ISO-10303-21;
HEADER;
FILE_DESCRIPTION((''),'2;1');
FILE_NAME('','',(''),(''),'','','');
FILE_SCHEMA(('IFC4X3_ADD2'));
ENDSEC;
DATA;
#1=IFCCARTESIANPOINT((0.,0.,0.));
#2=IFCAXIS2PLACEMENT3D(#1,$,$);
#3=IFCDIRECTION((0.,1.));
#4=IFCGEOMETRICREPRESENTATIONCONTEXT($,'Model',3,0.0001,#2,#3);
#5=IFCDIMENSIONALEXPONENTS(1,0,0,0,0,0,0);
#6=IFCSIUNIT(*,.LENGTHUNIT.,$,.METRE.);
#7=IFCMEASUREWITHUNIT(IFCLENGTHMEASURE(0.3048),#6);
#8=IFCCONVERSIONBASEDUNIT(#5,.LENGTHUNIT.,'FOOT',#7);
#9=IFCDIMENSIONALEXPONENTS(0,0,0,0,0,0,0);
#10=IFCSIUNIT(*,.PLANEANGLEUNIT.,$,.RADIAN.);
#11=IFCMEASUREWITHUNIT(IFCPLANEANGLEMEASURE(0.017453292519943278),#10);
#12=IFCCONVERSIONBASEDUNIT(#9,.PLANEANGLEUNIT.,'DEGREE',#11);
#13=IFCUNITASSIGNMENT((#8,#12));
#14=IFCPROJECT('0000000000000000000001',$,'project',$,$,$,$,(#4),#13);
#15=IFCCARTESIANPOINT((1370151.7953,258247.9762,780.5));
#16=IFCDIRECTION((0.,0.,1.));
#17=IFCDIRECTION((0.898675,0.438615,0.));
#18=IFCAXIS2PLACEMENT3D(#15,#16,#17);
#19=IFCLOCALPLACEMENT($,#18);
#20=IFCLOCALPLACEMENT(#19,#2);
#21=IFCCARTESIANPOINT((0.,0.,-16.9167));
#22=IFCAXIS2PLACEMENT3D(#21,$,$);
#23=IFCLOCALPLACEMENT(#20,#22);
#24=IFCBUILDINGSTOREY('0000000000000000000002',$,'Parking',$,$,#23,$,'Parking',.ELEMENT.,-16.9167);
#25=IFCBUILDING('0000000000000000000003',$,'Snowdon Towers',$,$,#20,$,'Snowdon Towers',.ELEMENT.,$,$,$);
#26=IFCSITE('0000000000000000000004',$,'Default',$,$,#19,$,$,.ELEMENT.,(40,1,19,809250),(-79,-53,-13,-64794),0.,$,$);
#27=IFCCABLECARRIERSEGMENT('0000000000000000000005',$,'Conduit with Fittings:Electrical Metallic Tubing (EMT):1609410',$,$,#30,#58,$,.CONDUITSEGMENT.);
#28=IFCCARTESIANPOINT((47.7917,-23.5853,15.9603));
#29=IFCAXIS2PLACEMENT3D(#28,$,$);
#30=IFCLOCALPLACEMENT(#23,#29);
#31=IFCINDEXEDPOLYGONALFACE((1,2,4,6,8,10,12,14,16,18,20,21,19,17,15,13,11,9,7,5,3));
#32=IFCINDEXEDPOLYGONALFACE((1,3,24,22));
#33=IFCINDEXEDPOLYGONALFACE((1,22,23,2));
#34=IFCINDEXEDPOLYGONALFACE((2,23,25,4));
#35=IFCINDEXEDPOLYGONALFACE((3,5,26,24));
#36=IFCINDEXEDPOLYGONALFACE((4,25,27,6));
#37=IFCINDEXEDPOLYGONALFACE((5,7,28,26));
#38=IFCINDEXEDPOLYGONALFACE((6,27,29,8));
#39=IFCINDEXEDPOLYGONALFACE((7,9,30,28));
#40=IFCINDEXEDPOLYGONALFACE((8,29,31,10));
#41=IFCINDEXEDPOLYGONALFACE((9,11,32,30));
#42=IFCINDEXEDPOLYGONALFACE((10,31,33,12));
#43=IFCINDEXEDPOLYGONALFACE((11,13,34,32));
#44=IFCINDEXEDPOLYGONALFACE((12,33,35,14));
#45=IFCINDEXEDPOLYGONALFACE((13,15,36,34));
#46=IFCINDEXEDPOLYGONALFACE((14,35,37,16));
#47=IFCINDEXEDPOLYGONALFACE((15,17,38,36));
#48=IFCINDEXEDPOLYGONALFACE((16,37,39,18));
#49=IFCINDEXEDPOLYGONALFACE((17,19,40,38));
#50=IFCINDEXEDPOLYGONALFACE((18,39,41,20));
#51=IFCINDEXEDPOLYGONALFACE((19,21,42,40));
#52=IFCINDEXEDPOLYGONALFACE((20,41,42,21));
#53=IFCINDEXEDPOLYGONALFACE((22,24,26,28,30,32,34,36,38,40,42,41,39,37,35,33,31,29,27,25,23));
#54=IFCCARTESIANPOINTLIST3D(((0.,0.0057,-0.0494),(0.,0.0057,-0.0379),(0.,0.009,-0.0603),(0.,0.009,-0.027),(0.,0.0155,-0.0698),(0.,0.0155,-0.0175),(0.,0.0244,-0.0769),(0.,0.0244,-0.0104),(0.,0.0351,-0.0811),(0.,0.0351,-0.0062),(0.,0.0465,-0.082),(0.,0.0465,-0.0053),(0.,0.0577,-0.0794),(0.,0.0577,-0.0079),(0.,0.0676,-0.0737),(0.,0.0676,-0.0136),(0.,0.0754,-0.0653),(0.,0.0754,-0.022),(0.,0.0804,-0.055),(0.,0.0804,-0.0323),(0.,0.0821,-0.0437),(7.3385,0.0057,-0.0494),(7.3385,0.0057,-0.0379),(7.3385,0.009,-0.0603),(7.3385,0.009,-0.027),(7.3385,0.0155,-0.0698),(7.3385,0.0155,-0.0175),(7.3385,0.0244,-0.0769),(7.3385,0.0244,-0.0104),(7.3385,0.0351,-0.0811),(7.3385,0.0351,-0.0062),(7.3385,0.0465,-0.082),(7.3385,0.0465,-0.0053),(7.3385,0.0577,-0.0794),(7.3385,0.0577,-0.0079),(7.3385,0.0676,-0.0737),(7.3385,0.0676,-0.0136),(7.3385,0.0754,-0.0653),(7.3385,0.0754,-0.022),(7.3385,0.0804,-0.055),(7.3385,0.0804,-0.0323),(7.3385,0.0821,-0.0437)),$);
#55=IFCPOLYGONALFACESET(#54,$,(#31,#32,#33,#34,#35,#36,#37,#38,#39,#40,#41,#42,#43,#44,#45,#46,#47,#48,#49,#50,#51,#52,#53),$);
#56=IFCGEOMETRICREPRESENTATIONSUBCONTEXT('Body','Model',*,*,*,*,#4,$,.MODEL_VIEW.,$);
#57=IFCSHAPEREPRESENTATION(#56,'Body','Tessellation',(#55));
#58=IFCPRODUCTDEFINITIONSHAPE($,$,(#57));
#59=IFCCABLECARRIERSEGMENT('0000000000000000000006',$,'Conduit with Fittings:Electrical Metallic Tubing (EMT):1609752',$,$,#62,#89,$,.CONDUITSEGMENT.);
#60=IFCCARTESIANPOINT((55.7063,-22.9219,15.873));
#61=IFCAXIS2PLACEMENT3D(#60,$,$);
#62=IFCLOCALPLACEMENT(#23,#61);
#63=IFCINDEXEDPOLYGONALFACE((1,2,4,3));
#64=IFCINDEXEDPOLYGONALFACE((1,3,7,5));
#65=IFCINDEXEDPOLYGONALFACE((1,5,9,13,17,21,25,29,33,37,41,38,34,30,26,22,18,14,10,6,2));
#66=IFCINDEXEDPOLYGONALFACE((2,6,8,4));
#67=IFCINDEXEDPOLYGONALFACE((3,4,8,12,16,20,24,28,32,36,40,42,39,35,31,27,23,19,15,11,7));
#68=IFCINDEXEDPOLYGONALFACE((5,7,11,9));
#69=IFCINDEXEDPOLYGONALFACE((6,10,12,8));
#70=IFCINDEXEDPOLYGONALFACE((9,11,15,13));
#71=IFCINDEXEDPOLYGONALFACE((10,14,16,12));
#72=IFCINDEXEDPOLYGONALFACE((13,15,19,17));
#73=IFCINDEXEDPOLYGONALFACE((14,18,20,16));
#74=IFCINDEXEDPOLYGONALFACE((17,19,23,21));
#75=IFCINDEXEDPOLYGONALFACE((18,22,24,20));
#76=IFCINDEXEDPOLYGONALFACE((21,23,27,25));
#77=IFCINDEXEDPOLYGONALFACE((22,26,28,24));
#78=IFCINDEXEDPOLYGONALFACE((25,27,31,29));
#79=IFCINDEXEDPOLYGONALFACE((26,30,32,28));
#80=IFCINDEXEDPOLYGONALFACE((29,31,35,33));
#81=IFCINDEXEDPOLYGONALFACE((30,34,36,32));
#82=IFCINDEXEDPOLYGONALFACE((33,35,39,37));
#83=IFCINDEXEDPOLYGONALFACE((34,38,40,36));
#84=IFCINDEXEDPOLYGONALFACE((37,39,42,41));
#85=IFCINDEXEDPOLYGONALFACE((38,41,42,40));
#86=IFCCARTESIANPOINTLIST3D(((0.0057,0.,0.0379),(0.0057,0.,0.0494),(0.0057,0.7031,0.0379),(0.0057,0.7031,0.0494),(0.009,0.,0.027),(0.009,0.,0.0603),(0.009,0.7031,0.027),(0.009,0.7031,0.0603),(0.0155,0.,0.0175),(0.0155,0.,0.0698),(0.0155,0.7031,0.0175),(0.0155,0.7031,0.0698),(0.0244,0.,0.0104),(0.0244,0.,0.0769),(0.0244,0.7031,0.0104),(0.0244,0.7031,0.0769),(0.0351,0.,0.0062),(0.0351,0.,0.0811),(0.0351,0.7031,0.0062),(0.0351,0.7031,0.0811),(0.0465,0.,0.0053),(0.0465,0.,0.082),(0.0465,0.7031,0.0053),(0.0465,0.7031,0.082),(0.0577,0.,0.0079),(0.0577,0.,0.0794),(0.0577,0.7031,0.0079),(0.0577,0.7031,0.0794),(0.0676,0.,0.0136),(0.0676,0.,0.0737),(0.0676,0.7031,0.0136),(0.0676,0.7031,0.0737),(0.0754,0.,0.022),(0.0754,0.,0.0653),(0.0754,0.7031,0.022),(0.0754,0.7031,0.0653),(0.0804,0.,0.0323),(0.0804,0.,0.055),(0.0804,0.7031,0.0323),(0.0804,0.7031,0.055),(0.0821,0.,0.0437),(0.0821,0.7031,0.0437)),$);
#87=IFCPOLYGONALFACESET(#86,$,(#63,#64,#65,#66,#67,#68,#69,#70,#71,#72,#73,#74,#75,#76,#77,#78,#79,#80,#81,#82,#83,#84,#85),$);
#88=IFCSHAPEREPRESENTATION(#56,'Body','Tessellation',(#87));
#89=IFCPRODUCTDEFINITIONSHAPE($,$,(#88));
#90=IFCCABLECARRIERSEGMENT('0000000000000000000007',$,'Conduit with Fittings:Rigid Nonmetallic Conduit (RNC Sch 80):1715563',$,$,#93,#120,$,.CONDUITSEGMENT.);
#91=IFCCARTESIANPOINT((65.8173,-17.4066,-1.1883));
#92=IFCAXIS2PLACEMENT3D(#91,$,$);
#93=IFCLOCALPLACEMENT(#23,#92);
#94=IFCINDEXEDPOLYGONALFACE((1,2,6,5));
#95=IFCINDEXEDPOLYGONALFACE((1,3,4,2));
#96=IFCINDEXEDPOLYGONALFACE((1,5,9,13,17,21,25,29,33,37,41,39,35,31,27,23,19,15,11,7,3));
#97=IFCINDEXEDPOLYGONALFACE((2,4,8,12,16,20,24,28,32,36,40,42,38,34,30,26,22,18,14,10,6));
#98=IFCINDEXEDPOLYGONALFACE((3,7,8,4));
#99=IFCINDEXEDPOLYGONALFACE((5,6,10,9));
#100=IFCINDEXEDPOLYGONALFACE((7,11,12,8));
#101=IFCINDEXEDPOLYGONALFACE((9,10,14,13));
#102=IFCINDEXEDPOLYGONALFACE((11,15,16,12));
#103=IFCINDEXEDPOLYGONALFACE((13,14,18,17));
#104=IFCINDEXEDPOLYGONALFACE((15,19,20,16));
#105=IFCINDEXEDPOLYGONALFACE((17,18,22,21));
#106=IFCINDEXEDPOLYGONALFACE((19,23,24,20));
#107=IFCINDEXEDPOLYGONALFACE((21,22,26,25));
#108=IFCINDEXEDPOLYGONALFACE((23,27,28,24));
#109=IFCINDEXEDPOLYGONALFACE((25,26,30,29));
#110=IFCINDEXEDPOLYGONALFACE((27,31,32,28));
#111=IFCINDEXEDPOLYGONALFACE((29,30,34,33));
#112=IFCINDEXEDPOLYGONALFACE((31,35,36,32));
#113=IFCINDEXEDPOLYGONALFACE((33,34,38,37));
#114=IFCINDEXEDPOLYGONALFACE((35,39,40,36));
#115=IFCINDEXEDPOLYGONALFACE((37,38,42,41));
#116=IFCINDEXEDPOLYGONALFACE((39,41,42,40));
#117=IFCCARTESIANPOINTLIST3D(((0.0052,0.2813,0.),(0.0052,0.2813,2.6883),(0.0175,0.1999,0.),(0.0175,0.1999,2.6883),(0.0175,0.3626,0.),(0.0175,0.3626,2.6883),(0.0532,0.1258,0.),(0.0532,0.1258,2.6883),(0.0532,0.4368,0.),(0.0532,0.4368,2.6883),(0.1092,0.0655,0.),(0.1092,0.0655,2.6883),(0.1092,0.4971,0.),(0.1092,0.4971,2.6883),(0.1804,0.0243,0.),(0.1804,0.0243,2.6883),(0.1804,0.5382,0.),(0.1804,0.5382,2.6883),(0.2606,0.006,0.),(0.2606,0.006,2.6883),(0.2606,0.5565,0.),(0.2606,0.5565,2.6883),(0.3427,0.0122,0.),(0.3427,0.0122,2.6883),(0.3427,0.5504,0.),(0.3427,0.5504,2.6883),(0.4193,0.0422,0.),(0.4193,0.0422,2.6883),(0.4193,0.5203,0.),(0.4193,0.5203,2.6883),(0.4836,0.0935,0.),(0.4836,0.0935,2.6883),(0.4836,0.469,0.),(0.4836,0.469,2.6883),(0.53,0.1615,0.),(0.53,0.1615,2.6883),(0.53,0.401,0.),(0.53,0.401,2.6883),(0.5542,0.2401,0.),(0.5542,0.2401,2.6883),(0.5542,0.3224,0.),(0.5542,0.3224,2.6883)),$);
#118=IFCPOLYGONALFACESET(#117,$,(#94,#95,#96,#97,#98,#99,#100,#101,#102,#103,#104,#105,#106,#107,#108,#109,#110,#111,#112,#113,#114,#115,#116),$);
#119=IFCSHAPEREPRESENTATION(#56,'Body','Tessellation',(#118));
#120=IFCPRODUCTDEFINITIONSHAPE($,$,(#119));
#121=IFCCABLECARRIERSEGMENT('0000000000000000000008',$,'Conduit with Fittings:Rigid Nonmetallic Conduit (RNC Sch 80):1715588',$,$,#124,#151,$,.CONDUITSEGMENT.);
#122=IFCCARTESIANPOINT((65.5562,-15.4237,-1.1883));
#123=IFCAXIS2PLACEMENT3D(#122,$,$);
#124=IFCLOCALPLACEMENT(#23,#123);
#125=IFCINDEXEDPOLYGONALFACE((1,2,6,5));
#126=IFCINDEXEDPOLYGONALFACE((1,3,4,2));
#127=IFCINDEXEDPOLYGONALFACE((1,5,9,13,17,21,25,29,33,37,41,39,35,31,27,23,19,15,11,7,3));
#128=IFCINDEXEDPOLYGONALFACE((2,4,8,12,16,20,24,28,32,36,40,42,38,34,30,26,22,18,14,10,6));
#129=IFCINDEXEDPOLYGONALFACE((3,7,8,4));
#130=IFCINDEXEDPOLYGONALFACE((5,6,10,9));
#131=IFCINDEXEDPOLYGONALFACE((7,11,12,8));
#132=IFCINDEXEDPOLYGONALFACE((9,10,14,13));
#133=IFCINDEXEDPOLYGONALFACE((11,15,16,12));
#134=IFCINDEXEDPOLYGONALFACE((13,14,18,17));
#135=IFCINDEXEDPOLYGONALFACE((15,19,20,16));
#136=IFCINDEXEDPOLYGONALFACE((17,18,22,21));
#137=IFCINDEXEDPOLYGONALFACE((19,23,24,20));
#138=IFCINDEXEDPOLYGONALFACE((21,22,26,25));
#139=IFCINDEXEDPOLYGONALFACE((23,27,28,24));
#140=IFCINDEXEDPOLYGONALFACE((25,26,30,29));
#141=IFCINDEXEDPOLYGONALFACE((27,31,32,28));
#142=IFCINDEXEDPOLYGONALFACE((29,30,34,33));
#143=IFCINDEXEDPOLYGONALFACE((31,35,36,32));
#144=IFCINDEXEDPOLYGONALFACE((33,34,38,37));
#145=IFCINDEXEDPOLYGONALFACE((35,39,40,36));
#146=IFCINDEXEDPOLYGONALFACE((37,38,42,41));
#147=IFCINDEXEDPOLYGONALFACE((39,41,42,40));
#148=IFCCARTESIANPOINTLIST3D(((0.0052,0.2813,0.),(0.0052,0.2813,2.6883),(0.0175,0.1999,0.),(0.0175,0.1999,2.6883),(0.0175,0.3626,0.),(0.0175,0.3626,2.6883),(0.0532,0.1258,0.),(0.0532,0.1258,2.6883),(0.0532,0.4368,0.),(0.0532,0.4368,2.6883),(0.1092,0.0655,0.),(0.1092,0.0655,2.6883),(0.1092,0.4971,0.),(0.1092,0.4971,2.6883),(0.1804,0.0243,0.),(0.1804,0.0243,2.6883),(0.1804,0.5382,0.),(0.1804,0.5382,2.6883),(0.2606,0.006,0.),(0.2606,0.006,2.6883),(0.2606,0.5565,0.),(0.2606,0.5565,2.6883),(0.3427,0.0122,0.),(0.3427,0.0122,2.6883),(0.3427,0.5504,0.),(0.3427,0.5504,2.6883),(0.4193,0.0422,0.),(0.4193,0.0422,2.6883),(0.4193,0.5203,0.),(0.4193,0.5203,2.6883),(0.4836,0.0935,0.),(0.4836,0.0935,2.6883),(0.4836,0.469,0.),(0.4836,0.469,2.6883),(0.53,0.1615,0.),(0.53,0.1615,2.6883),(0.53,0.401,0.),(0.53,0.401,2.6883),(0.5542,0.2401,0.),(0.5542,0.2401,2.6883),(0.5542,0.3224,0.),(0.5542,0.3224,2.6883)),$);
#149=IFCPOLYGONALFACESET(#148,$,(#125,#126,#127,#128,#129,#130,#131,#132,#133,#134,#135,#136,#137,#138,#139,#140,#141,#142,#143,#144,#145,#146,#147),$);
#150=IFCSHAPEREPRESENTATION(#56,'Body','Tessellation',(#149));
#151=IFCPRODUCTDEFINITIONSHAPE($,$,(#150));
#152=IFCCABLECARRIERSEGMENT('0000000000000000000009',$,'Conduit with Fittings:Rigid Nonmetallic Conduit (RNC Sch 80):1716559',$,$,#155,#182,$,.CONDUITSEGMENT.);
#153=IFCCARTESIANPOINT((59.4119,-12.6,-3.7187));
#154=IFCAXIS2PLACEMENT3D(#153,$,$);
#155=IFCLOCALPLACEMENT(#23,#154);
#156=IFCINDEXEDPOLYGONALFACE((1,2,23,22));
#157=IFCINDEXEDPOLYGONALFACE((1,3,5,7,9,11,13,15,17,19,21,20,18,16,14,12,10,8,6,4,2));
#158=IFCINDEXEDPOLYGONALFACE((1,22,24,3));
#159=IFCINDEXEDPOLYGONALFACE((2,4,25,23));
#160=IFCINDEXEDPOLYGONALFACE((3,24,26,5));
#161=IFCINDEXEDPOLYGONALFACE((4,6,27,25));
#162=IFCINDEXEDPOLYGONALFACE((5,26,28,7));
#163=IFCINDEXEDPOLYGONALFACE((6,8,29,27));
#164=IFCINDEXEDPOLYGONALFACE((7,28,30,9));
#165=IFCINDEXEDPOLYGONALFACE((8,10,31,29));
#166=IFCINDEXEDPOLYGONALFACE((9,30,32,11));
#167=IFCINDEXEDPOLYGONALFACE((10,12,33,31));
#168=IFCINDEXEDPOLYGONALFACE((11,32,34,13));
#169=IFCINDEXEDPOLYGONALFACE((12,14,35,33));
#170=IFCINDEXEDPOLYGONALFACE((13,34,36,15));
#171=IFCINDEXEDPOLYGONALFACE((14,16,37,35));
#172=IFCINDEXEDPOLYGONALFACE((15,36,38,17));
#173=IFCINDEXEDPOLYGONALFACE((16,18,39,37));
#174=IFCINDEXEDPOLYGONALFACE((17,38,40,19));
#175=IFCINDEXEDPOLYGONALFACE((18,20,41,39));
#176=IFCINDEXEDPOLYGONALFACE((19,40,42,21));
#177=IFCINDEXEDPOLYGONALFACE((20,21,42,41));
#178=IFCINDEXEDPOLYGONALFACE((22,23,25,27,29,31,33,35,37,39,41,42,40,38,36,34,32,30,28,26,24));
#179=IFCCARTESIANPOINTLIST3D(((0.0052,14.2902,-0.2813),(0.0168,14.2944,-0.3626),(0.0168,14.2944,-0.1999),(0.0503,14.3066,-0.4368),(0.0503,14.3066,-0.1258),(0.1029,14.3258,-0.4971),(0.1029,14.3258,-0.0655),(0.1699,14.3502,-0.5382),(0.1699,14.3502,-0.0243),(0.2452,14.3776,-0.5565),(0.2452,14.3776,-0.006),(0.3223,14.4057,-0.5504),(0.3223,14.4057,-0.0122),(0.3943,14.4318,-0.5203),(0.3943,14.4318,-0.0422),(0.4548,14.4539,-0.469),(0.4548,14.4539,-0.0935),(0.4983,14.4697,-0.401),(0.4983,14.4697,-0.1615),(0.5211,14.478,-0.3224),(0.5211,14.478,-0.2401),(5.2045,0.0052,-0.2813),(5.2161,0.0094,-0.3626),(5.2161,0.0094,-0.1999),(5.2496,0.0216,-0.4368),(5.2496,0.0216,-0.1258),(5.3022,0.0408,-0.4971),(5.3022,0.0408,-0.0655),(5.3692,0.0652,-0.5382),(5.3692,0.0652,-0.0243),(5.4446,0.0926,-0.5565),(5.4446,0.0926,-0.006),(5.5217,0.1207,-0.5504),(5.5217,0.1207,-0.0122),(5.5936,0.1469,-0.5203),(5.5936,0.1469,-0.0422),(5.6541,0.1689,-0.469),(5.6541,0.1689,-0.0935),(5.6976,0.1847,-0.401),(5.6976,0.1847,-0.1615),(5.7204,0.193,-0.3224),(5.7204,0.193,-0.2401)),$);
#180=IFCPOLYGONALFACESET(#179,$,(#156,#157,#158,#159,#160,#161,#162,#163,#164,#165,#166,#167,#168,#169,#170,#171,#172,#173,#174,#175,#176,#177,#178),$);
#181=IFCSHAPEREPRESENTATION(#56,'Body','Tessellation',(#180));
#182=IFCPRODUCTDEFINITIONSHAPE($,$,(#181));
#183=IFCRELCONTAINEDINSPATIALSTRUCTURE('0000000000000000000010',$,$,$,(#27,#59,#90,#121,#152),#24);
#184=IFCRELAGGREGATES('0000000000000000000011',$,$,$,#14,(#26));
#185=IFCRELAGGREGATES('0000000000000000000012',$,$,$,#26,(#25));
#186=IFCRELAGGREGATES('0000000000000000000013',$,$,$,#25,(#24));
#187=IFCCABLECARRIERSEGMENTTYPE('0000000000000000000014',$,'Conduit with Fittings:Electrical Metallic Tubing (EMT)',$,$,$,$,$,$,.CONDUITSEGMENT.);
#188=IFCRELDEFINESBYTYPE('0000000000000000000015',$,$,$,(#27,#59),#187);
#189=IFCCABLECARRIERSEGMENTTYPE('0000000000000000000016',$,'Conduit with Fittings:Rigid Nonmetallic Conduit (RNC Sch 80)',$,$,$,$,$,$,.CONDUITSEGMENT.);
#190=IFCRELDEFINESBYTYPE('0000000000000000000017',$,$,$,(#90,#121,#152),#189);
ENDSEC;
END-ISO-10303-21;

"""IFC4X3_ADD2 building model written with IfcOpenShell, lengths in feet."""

from ifc_helpers import new_model, entity, si_unit, converted_unit, direction, frame, frame_2d, origin, place, context, subcontext, project, spatial, circle, extrude, type_object, element, save


model = new_model("IFC4X3_ADD2")

# Units and contexts
model_context = context("Model", 3, precision=0.0001, world=origin(), true_north=direction((0.0, 1.0)))
body_context = subcontext(model_context, "Body", "Model", "MODEL_VIEW")
ifc_project = project(units=[converted_unit("LENGTHUNIT", "FOOT", entity("IfcLengthMeasure", 0.3048), si_unit("LENGTHUNIT", "METRE"), dimensions=[1, 0, 0, 0, 0, 0, 0]), converted_unit("PLANEANGLEUNIT", "DEGREE", entity("IfcPlaneAngleMeasure", 0.017453292519943278), si_unit("PLANEANGLEUNIT", "RADIAN"), dimensions=[0, 0, 0, 0, 0, 0, 0])], contexts=[model_context])

# Site, building, storey
site_placement = place(None, frame((1370151.7953, 258247.9762, 780.5), z_axis=(0.0, 0.0, 1.0), x_axis=(0.898675, 0.438615, 0.0)))
site = spatial("IfcSite", under=ifc_project, at=site_placement, Name="Default", CompositionType="ELEMENT", RefLatitude=(40, 1, 19, 809250), RefLongitude=(-79, -53, -13, -64794), RefElevation=0.0)
building_placement = place(site_placement, origin())
building = spatial("IfcBuilding", under=site, at=building_placement, Name="Snowdon Towers", LongName="Snowdon Towers", CompositionType="ELEMENT")
storey_placement = place(building_placement, frame((0.0, 0.0, -16.9167)))
storey = spatial("IfcBuildingStorey", under=building, at=storey_placement, Name="Parking", LongName="Parking", CompositionType="ELEMENT", Elevation=-16.9167)

# Cable carrier segments
cable_carrier_segment_type_1 = type_object("IfcCableCarrierSegmentType", Name="Conduit with Fittings:Electrical Metallic Tubing (EMT)", PredefinedType="CONDUITSEGMENT")
cable_carrier_segment_1_placement = place(storey_placement, frame((47.7917, -23.5853, 15.9603)))
element("IfcCableCarrierSegment", 1, at=cable_carrier_segment_1_placement, inside=storey, type_object=cable_carrier_segment_type_1, Name="Conduit with Fittings:Electrical Metallic Tubing (EMT):1609410", PredefinedType="CONDUITSEGMENT", context=body_context, shape_type="SweptSolid", body=[
    extrude(circle(Radius=0.0384, at=frame_2d((0.0, 0.0), x_axis=(1.0, 0.0))), frame((0.0, 0.0437, -0.0437), z_axis=(1.0, 0.0, 0.0), x_axis=(0.0, 1.0, 0.0)), (0.0, 0.0, 1.0), 7.3385),
])
cable_carrier_segment_2_placement = place(storey_placement, frame((55.7063, -22.9219, 15.873)))
element("IfcCableCarrierSegment", 2, at=cable_carrier_segment_2_placement, inside=storey, type_object=cable_carrier_segment_type_1, Name="Conduit with Fittings:Electrical Metallic Tubing (EMT):1609752", PredefinedType="CONDUITSEGMENT", context=body_context, shape_type="SweptSolid", body=[
    extrude(circle(Radius=0.0384, at=frame_2d((0.0, 0.0), x_axis=(1.0, 0.0))), frame((0.0437, 0.0, 0.0437), z_axis=(0.0, 1.0, 0.0), x_axis=(1.0, 0.0, 0.0)), (0.0, 0.0, 1.0), 0.7031),
])

# Cable carrier segments
cable_carrier_segment_type_2 = type_object("IfcCableCarrierSegmentType", Name="Conduit with Fittings:Rigid Nonmetallic Conduit (RNC Sch 80)", PredefinedType="CONDUITSEGMENT")
cable_carrier_segment_3_placement = place(storey_placement, frame((65.8173, -17.4066, -1.1883)))
element("IfcCableCarrierSegment", 3, at=cable_carrier_segment_3_placement, inside=storey, type_object=cable_carrier_segment_type_2, Name="Conduit with Fittings:Rigid Nonmetallic Conduit (RNC Sch 80):1715563", PredefinedType="CONDUITSEGMENT", context=body_context, shape_type="SweptSolid", body=[
    extrude(circle(Radius=0.276, at=frame_2d((0.0, 0.0), x_axis=(1.0, 0.0))), frame((0.2813, 0.2813, 0.0), z_axis=(0.0, 0.0, 1.0), x_axis=(-1.0, 0.0, 0.0)), (0.0, 0.0, 1.0), 2.6883),
])
cable_carrier_segment_4_placement = place(storey_placement, frame((65.5562, -15.4237, -1.1883)))
element("IfcCableCarrierSegment", 4, at=cable_carrier_segment_4_placement, inside=storey, type_object=cable_carrier_segment_type_2, Name="Conduit with Fittings:Rigid Nonmetallic Conduit (RNC Sch 80):1715588", PredefinedType="CONDUITSEGMENT", context=body_context, shape_type="SweptSolid", body=[
    extrude(circle(Radius=0.276, at=frame_2d((0.0, 0.0), x_axis=(1.0, 0.0))), frame((0.2813, 0.2813, 0.0), z_axis=(0.0, 0.0, 1.0), x_axis=(-1.0, 0.0, 0.0)), (0.0, 0.0, 1.0), 2.6883),
])
cable_carrier_segment_5_placement = place(storey_placement, frame((59.4119, -12.6, -3.7187)))
element("IfcCableCarrierSegment", 5, at=cable_carrier_segment_5_placement, inside=storey, type_object=cable_carrier_segment_type_2, Name="Conduit with Fittings:Rigid Nonmetallic Conduit (RNC Sch 80):1716559", PredefinedType="CONDUITSEGMENT", context=body_context, shape_type="SweptSolid", body=[
    extrude(circle(Radius=0.276, at=frame_2d((0.0, 0.0), x_axis=(1.0, 0.0))), frame((5.4639, 0.0996, -0.2813), z_axis=(-0.34202, 0.939693, 0.0), x_axis=(-0.939693, -0.34202, 0.0)), (0.0, 0.0, 1.0), 15.2018),
])

save(model, "model.ifc")
